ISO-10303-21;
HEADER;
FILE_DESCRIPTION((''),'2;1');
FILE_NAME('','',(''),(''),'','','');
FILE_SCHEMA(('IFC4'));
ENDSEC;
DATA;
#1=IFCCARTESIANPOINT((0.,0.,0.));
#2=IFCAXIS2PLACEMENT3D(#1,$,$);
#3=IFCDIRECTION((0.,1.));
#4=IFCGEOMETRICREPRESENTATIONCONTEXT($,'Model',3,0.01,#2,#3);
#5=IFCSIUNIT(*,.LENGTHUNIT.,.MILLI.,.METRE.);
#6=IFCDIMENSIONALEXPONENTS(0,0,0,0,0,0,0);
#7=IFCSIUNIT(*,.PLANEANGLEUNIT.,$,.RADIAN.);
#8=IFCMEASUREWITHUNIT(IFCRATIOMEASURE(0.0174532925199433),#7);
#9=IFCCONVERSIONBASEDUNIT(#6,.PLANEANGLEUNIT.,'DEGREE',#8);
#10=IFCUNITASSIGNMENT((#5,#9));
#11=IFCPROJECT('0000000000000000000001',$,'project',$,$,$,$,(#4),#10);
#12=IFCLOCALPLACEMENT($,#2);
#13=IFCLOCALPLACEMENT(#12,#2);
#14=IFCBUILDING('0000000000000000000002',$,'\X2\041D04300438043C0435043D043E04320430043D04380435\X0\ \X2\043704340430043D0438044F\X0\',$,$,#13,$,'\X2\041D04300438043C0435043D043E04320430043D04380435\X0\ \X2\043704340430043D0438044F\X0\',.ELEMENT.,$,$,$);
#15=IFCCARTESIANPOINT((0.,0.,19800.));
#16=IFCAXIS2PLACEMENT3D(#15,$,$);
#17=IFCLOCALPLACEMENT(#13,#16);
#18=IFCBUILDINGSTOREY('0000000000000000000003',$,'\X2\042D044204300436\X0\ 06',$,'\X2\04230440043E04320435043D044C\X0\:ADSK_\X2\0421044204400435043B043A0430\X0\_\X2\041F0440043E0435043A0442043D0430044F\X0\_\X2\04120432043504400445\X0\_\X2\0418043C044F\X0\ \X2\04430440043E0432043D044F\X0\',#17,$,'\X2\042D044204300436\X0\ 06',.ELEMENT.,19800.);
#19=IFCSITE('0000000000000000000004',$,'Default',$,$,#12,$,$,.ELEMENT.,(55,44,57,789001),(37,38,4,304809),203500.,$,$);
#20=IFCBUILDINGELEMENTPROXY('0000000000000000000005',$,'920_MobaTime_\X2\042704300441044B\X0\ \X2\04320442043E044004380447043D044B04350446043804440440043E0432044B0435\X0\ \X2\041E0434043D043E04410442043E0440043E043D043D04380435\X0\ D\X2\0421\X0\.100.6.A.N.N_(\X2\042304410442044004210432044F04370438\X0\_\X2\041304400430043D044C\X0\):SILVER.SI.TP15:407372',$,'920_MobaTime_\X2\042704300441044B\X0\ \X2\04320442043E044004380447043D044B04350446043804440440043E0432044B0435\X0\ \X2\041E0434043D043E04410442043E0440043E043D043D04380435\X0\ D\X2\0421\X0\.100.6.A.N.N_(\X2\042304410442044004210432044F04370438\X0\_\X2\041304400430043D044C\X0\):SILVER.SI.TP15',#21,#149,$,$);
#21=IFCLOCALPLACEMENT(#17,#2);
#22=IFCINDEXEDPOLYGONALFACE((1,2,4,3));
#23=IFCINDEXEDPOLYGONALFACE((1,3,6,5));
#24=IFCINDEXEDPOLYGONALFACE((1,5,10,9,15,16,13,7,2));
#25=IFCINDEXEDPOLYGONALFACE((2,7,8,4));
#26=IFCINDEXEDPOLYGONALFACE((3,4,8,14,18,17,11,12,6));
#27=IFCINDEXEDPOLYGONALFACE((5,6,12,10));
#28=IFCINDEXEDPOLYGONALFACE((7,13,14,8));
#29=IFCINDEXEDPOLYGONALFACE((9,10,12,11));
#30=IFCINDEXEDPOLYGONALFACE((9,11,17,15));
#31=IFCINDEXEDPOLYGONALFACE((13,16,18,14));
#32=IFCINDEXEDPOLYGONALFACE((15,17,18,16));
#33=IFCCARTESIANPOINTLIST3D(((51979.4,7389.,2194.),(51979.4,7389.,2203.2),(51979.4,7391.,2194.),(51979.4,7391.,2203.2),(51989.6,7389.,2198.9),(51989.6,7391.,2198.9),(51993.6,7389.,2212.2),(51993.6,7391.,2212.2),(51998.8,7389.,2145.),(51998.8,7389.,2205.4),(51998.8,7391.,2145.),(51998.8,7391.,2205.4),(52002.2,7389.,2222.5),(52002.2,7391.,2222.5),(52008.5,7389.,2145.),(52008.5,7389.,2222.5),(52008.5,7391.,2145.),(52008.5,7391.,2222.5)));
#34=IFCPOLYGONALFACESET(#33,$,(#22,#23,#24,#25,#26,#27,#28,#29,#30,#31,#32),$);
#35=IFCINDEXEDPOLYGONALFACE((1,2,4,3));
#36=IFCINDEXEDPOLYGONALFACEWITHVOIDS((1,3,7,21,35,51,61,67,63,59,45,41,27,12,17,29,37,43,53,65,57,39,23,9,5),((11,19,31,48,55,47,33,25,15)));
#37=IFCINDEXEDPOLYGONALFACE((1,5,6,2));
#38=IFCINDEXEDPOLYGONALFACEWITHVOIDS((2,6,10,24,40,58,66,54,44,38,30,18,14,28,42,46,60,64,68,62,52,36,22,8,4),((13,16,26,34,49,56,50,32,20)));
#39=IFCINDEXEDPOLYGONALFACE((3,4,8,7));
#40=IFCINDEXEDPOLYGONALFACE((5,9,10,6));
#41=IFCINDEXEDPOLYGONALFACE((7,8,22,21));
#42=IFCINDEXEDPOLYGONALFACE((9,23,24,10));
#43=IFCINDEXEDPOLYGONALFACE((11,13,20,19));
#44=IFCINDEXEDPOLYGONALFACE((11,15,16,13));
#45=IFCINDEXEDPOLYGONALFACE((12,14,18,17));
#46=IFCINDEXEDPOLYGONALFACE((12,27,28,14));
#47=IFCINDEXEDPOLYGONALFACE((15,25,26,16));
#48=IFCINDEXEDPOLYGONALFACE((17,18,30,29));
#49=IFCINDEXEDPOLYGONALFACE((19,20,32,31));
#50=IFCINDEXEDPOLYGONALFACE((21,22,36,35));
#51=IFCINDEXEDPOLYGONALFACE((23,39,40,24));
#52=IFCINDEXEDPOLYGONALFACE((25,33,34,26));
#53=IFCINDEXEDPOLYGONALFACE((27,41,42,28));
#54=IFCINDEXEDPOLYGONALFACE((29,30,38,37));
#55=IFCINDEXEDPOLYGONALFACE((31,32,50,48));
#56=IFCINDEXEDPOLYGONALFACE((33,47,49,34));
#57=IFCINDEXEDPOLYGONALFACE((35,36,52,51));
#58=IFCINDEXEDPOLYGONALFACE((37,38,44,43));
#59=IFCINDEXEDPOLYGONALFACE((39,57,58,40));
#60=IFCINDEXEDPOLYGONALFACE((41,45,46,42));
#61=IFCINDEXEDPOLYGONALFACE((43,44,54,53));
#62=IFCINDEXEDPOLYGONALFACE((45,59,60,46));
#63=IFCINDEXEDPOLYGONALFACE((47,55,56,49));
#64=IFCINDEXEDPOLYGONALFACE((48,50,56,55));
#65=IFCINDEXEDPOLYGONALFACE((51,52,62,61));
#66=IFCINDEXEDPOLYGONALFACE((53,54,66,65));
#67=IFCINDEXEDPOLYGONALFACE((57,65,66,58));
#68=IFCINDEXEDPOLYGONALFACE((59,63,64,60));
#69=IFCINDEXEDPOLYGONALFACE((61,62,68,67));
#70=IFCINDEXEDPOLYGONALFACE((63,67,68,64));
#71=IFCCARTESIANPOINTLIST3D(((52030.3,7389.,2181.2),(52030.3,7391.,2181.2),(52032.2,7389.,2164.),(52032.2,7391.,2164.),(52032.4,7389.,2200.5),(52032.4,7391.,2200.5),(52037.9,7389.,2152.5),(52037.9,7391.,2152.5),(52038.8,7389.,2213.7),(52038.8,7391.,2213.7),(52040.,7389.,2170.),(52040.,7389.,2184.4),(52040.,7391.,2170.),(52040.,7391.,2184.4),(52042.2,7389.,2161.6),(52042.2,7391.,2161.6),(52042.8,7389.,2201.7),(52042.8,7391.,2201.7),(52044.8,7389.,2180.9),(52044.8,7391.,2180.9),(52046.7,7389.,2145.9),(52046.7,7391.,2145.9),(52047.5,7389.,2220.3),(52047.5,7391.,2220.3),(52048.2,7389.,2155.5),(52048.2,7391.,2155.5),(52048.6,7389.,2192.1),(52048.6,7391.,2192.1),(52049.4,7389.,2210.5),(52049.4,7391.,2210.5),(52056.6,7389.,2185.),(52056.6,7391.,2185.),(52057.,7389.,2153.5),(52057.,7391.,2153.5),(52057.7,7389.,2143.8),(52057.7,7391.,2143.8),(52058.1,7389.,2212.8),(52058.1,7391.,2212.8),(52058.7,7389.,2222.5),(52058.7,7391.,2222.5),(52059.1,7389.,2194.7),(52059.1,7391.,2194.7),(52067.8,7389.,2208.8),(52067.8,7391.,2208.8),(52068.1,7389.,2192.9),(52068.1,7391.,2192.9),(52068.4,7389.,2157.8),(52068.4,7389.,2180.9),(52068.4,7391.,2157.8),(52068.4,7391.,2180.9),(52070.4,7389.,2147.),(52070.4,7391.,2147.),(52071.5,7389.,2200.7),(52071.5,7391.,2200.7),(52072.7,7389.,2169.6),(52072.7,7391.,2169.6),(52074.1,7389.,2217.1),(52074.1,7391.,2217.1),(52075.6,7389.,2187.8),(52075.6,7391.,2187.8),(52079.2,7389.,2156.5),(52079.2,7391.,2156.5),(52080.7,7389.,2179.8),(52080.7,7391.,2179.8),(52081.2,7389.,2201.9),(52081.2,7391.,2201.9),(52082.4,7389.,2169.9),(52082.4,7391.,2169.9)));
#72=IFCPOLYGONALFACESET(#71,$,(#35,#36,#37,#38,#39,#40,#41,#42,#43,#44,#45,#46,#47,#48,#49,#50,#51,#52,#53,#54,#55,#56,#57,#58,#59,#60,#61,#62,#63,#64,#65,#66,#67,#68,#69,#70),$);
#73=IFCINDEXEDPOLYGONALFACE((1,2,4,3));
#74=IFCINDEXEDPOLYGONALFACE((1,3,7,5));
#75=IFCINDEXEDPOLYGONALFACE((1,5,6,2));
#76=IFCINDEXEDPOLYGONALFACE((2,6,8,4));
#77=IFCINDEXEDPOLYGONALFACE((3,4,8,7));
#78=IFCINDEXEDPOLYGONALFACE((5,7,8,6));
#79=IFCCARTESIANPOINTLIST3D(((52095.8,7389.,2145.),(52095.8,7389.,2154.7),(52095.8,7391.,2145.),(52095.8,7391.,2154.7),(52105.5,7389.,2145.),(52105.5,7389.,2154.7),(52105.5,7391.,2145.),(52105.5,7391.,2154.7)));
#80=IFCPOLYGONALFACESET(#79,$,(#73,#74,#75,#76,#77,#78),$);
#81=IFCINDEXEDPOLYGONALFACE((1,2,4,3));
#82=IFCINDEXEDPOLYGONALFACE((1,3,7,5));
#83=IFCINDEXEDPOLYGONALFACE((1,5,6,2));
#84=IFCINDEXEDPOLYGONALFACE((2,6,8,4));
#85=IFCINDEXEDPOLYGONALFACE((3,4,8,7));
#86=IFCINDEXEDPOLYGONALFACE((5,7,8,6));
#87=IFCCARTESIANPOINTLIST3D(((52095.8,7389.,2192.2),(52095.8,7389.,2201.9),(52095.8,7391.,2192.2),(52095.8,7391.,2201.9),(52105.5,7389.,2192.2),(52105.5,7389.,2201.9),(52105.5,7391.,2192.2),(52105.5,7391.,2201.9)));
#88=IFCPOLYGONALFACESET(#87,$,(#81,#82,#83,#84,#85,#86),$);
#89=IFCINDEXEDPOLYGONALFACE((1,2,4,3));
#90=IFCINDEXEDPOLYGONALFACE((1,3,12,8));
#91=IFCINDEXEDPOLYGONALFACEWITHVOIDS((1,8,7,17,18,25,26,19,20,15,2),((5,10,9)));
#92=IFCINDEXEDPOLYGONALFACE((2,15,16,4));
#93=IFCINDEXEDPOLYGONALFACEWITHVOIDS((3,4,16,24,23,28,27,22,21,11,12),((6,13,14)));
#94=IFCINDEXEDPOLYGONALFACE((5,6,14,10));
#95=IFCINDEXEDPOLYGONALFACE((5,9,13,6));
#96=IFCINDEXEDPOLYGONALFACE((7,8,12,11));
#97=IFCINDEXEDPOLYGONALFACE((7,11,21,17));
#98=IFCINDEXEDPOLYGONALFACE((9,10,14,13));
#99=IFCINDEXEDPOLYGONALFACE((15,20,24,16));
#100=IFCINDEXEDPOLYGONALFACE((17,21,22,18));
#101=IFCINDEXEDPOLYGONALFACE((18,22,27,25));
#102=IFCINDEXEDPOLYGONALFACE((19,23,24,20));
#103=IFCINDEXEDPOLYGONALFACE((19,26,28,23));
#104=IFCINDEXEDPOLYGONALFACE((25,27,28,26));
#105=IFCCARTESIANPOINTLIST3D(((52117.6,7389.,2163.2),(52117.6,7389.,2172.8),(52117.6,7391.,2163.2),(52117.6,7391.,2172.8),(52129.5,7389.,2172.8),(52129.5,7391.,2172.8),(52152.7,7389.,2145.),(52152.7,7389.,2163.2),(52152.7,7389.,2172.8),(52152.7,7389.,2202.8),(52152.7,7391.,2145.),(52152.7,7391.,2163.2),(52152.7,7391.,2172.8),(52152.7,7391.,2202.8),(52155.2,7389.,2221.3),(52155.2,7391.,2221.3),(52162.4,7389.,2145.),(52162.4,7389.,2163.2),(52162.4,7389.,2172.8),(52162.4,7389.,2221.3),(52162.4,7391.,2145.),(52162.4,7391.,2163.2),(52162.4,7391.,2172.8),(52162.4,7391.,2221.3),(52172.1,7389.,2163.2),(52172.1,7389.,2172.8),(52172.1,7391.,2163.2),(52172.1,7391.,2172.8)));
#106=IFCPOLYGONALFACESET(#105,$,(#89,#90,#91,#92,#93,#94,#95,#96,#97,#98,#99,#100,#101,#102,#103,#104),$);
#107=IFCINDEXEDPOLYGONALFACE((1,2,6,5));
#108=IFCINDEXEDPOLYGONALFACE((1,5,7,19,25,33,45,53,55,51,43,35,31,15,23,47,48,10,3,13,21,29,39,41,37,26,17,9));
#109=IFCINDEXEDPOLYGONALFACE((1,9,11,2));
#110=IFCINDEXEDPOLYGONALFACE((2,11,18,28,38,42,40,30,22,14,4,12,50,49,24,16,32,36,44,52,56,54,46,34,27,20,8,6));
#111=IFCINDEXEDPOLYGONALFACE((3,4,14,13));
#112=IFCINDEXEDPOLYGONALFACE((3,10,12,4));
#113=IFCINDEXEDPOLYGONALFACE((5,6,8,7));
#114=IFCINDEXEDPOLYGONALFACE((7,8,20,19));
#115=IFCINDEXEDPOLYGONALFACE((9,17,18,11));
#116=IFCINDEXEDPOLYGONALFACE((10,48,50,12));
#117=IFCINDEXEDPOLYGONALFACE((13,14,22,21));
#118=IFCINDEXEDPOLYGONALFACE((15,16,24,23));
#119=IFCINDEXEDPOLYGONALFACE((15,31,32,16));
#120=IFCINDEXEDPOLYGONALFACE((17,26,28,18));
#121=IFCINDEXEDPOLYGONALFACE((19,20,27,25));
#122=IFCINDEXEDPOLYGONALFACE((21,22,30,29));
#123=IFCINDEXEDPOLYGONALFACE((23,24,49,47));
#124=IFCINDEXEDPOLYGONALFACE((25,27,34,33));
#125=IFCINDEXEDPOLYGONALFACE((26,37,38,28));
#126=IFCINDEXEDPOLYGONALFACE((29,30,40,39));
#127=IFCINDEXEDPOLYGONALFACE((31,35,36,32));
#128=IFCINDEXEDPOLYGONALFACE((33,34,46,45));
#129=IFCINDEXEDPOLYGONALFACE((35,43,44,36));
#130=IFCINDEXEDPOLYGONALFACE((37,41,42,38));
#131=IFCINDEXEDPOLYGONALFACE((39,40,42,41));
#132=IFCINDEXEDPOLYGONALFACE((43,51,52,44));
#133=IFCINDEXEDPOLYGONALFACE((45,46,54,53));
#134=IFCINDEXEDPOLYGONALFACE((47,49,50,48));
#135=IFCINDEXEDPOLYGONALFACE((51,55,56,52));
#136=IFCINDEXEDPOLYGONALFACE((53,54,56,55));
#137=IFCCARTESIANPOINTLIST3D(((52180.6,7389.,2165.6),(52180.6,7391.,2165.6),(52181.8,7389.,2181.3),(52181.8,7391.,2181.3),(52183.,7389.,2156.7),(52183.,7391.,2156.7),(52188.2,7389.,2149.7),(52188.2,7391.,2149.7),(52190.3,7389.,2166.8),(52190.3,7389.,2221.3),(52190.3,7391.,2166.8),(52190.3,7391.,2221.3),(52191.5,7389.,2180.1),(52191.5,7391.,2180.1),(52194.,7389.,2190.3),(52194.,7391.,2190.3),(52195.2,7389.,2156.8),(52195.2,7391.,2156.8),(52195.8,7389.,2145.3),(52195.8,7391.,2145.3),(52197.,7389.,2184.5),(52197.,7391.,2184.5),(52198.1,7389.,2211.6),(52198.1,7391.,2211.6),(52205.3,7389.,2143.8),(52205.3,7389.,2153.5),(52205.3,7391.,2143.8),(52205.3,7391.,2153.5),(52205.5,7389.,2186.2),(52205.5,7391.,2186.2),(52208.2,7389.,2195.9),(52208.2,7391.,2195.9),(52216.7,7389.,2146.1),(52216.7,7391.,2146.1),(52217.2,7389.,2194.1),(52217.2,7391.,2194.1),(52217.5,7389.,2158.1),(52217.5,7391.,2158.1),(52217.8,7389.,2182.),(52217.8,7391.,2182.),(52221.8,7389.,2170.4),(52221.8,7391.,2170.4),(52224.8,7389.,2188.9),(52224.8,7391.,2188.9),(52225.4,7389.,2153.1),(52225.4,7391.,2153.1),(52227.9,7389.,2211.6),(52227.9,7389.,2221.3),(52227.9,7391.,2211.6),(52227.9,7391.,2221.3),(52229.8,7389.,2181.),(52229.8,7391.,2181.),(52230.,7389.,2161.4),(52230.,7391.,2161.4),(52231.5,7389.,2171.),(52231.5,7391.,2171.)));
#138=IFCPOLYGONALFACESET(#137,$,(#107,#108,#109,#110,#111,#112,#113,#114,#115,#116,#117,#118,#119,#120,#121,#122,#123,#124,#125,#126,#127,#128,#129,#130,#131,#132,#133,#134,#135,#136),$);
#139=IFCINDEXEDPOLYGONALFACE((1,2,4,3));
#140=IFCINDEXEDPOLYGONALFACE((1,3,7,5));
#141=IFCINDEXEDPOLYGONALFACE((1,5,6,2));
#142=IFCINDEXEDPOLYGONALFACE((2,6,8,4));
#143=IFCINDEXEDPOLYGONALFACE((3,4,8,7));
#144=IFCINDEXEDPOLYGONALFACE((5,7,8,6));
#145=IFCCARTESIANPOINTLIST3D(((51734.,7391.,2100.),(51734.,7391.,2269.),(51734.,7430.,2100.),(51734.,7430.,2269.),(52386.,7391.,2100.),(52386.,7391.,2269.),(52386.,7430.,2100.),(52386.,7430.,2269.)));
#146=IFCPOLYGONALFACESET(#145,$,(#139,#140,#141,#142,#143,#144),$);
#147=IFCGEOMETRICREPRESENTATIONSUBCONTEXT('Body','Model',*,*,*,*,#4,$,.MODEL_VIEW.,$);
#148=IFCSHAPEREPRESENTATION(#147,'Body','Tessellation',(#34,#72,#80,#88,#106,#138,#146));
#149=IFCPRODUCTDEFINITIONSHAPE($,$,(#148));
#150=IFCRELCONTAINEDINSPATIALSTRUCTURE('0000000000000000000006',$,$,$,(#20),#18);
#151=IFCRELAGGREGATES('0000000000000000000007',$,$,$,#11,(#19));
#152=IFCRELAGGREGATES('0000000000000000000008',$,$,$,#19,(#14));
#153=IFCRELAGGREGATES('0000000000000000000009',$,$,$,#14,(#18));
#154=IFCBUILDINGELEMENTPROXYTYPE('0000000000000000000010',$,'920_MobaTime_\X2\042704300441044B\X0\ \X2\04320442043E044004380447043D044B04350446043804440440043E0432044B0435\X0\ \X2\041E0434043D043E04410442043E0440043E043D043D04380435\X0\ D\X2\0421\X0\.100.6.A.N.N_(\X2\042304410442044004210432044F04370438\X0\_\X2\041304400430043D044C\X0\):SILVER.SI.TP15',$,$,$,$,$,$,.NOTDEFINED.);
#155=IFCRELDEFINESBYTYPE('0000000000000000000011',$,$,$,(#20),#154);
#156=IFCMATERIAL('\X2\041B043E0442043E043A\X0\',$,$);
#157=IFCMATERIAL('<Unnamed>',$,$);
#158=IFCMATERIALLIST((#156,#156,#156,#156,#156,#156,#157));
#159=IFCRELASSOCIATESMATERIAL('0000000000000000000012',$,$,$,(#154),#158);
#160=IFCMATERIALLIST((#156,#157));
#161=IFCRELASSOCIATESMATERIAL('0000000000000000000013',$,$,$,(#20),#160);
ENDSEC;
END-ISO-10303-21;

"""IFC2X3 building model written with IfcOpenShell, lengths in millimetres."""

from ifc_helpers import new_model, entity, si_unit, converted_unit, direction, frame, origin, origin_2d_with_axis, place, context, subcontext, project, spatial, polyline, rectangle, outline, extrude, source, transform, mapped, material, material_list, type_object, type_shapes, element, save


model = new_model("IFC2X3")

# Units and contexts
model_context = context("Model", 3, precision=0.01, world=origin(), true_north=direction((0.0, 1.0)))
body_context = subcontext(model_context, "Body", "Model", "MODEL_VIEW")
ifc_project = project(units=[si_unit("LENGTHUNIT", "METRE", prefix="MILLI"), converted_unit("PLANEANGLEUNIT", "DEGREE", entity("IfcRatioMeasure", 0.0174532925199433), si_unit("PLANEANGLEUNIT", "RADIAN"), dimensions=[0, 0, 0, 0, 0, 0, 0])], contexts=[model_context])

# Site, building, storey
site_placement = place(None, frame((0.0, 0.0, 0.0)))
site = spatial("IfcSite", under=ifc_project, at=site_placement, Name="Default", CompositionType="ELEMENT", RefLatitude=(55, 44, 57, 789001), RefLongitude=(37, 38, 4, 304809), RefElevation=203500.0)
building_placement = place(site_placement, origin())
building = spatial("IfcBuilding", under=site, at=building_placement, Name="Наименование здания", LongName="Наименование здания", CompositionType="ELEMENT")
storey_placement = place(building_placement, frame((0.0, 0.0, 19800.0)))
storey = spatial("IfcBuildingStorey", under=building, at=storey_placement, Name="Этаж 06", ObjectType="Уровень:ADSK_Стрелка_Проектная_Вверх_Имя уровня", LongName="Этаж 06", CompositionType="ELEMENT", Elevation=19800.0)

# Building element proxy
ifc_material_1 = material(Name="Лоток")
ifc_material_2 = material(Name="<Unnamed>")
ifc_material_list_1 = material_list([ifc_material_1, ifc_material_1, ifc_material_1, ifc_material_1, ifc_material_1, ifc_material_1, ifc_material_2])
building_element_proxy_type_1 = type_object("IfcBuildingElementProxyType", Name="920_MobaTime_Часы вторичныецифровые Односторонние DС.100.6.A.N.N_(УстрСвязи_Грань):SILVER.SI.TP15", PredefinedType="NOTDEFINED", material=ifc_material_list_1)
shared_shape_1 = source(origin(), body_context, "Body", "SweptSolid", [
    extrude(outline(polyline([(-49.3, -13.1), (28.2, -13.1), (28.2, -6.8), (17.9, 1.8), (8.9, 16.0), (-0.3, 16.0), (4.6, 5.8), (11.1, -3.4), (-49.3, -3.4), (-49.3, -13.1)])), frame((-64.6, 9.8, 39.0), z_axis=(0.0, 0.0, 1.0), x_axis=(0.0, 1.0, 0.0)), (0.0, 0.0, 1.0), 2.0),
    extrude(outline(polyline([(2.2, -27.6), (19.0, -27.6), (30.5, -16.1), (33.3, -4.9), (31.0, 5.8), (21.8, 17.2), (5.2, 27.3), (-11.1, 33.0), (-24.0, 32.7), (-33.6, 27.6), (-40.3, 18.6), (-42.8, 5.7), (-38.0, -6.3), (-27.2, -15.0), (-17.5, -17.7), (-8.2, -16.4), (-0.3, -11.9), (5.1, -4.5), (7.3, 6.2), (4.0, 17.2), (18.5, 7.3), (23.6, -2.4), (22.0, -11.4), (14.2, -18.4), (5.3, -18.3), (2.2, -27.6)]), holes=[polyline([(-9.0, 23.3), (-1.3, 14.4), (-2.6, 2.0), (-11.4, -7.0), (-23.4, -6.1), (-32.2, 2.9), (-31.2, 15.1), (-25.6, 22.1), (-17.5, 24.9), (-9.0, 23.3)])]), frame((-2.7, 3.6, 39.0), z_axis=(0.0, 0.0, 1.0), x_axis=(-0.427649, 0.903945, 0.0)), (0.0, 0.0, 1.0), 2.0),
    extrude(rectangle(XDim=9.7, YDim=9.7, at=origin_2d_with_axis()), frame((40.6, -34.7, 39.0)), (0.0, 0.0, 1.0), 2.0),
    extrude(rectangle(XDim=9.7, YDim=9.7, at=origin_2d_with_axis()), frame((40.6, 12.6, 39.0)), (0.0, 0.0, 1.0), 2.0),
    extrude(outline(polyline([(-0.9, -28.1), (8.8, -28.1), (8.8, -9.9), (18.5, -9.9), (18.5, -0.2), (8.8, -0.2), (8.8, 48.3), (1.5, 48.3), (-36.0, -0.2), (-36.0, -9.9), (-0.9, -9.9), (-0.9, -28.1)]), holes=[polyline([(-0.9, -0.2), (-24.1, -0.2), (-0.9, 29.7), (-0.9, -0.2)])]), frame((93.6, -11.4, 39.0)), (0.0, 0.0, 1.0), 2.0),
    extrude(outline(polyline([(3.3, -28.3), (12.5, -28.3), (20.5, -25.0), (26.8, -18.8), (30.7, -10.0), (31.4, 1.6), (26.9, 11.8), (20.1, 18.4), (11.1, 22.3), (1.0, 23.3), (-7.9, 20.4), (-14.9, 14.5), (-18.9, 6.2), (-17.1, -9.0), (-36.7, 0.5), (-29.1, 29.3), (-38.5, 31.7), (-48.1, -4.6), (-11.6, -23.0), (-8.0, -14.0), (-10.8, -7.6), (-10.2, 1.1), (-3.0, 11.8), (9.2, 12.8), (20.0, 5.4), (21.3, -7.5), (15.5, -16.4), (4.6, -18.6), (3.3, -28.3)])), frame((147.1, -8.5, 39.0), z_axis=(0.0, 0.0, 1.0), x_axis=(0.256974, -0.966418, 0.0)), (0.0, 0.0, 1.0), 2.0),
    extrude(rectangle(XDim=652.0, YDim=169.0, at=origin_2d_with_axis()), frame((0.0, 0.0, 0.0), z_axis=(0.0, 0.0, 1.0), x_axis=(-1.0, 0.0, 0.0)), (0.0, 0.0, 1.0), 39.0),
])
type_shapes(building_element_proxy_type_1, [shared_shape_1])
ifc_material_list_2 = material_list([ifc_material_1, ifc_material_2])
proxy_1_placement = place(storey_placement, frame((52060.0, 7430.0, 2184.5), z_axis=(0.0, -1.0, 0.0), x_axis=(1.0, 0.0, 0.0)))
element("IfcBuildingElementProxy", 1, at=proxy_1_placement, inside=storey, type_object=building_element_proxy_type_1, material=ifc_material_list_2, Name="920_MobaTime_Часы вторичныецифровые Односторонние DС.100.6.A.N.N_(УстрСвязи_Грань):SILVER.SI.TP15:407372", ObjectType="920_MobaTime_Часы вторичныецифровые Односторонние DС.100.6.A.N.N_(УстрСвязи_Грань):SILVER.SI.TP15", context=body_context, shape_type="MappedRepresentation", body=[
    mapped(shared_shape_1, transform((0.0, 0.0, 0.0), scale=1.0)),
])

save(model, "model.ifc")
